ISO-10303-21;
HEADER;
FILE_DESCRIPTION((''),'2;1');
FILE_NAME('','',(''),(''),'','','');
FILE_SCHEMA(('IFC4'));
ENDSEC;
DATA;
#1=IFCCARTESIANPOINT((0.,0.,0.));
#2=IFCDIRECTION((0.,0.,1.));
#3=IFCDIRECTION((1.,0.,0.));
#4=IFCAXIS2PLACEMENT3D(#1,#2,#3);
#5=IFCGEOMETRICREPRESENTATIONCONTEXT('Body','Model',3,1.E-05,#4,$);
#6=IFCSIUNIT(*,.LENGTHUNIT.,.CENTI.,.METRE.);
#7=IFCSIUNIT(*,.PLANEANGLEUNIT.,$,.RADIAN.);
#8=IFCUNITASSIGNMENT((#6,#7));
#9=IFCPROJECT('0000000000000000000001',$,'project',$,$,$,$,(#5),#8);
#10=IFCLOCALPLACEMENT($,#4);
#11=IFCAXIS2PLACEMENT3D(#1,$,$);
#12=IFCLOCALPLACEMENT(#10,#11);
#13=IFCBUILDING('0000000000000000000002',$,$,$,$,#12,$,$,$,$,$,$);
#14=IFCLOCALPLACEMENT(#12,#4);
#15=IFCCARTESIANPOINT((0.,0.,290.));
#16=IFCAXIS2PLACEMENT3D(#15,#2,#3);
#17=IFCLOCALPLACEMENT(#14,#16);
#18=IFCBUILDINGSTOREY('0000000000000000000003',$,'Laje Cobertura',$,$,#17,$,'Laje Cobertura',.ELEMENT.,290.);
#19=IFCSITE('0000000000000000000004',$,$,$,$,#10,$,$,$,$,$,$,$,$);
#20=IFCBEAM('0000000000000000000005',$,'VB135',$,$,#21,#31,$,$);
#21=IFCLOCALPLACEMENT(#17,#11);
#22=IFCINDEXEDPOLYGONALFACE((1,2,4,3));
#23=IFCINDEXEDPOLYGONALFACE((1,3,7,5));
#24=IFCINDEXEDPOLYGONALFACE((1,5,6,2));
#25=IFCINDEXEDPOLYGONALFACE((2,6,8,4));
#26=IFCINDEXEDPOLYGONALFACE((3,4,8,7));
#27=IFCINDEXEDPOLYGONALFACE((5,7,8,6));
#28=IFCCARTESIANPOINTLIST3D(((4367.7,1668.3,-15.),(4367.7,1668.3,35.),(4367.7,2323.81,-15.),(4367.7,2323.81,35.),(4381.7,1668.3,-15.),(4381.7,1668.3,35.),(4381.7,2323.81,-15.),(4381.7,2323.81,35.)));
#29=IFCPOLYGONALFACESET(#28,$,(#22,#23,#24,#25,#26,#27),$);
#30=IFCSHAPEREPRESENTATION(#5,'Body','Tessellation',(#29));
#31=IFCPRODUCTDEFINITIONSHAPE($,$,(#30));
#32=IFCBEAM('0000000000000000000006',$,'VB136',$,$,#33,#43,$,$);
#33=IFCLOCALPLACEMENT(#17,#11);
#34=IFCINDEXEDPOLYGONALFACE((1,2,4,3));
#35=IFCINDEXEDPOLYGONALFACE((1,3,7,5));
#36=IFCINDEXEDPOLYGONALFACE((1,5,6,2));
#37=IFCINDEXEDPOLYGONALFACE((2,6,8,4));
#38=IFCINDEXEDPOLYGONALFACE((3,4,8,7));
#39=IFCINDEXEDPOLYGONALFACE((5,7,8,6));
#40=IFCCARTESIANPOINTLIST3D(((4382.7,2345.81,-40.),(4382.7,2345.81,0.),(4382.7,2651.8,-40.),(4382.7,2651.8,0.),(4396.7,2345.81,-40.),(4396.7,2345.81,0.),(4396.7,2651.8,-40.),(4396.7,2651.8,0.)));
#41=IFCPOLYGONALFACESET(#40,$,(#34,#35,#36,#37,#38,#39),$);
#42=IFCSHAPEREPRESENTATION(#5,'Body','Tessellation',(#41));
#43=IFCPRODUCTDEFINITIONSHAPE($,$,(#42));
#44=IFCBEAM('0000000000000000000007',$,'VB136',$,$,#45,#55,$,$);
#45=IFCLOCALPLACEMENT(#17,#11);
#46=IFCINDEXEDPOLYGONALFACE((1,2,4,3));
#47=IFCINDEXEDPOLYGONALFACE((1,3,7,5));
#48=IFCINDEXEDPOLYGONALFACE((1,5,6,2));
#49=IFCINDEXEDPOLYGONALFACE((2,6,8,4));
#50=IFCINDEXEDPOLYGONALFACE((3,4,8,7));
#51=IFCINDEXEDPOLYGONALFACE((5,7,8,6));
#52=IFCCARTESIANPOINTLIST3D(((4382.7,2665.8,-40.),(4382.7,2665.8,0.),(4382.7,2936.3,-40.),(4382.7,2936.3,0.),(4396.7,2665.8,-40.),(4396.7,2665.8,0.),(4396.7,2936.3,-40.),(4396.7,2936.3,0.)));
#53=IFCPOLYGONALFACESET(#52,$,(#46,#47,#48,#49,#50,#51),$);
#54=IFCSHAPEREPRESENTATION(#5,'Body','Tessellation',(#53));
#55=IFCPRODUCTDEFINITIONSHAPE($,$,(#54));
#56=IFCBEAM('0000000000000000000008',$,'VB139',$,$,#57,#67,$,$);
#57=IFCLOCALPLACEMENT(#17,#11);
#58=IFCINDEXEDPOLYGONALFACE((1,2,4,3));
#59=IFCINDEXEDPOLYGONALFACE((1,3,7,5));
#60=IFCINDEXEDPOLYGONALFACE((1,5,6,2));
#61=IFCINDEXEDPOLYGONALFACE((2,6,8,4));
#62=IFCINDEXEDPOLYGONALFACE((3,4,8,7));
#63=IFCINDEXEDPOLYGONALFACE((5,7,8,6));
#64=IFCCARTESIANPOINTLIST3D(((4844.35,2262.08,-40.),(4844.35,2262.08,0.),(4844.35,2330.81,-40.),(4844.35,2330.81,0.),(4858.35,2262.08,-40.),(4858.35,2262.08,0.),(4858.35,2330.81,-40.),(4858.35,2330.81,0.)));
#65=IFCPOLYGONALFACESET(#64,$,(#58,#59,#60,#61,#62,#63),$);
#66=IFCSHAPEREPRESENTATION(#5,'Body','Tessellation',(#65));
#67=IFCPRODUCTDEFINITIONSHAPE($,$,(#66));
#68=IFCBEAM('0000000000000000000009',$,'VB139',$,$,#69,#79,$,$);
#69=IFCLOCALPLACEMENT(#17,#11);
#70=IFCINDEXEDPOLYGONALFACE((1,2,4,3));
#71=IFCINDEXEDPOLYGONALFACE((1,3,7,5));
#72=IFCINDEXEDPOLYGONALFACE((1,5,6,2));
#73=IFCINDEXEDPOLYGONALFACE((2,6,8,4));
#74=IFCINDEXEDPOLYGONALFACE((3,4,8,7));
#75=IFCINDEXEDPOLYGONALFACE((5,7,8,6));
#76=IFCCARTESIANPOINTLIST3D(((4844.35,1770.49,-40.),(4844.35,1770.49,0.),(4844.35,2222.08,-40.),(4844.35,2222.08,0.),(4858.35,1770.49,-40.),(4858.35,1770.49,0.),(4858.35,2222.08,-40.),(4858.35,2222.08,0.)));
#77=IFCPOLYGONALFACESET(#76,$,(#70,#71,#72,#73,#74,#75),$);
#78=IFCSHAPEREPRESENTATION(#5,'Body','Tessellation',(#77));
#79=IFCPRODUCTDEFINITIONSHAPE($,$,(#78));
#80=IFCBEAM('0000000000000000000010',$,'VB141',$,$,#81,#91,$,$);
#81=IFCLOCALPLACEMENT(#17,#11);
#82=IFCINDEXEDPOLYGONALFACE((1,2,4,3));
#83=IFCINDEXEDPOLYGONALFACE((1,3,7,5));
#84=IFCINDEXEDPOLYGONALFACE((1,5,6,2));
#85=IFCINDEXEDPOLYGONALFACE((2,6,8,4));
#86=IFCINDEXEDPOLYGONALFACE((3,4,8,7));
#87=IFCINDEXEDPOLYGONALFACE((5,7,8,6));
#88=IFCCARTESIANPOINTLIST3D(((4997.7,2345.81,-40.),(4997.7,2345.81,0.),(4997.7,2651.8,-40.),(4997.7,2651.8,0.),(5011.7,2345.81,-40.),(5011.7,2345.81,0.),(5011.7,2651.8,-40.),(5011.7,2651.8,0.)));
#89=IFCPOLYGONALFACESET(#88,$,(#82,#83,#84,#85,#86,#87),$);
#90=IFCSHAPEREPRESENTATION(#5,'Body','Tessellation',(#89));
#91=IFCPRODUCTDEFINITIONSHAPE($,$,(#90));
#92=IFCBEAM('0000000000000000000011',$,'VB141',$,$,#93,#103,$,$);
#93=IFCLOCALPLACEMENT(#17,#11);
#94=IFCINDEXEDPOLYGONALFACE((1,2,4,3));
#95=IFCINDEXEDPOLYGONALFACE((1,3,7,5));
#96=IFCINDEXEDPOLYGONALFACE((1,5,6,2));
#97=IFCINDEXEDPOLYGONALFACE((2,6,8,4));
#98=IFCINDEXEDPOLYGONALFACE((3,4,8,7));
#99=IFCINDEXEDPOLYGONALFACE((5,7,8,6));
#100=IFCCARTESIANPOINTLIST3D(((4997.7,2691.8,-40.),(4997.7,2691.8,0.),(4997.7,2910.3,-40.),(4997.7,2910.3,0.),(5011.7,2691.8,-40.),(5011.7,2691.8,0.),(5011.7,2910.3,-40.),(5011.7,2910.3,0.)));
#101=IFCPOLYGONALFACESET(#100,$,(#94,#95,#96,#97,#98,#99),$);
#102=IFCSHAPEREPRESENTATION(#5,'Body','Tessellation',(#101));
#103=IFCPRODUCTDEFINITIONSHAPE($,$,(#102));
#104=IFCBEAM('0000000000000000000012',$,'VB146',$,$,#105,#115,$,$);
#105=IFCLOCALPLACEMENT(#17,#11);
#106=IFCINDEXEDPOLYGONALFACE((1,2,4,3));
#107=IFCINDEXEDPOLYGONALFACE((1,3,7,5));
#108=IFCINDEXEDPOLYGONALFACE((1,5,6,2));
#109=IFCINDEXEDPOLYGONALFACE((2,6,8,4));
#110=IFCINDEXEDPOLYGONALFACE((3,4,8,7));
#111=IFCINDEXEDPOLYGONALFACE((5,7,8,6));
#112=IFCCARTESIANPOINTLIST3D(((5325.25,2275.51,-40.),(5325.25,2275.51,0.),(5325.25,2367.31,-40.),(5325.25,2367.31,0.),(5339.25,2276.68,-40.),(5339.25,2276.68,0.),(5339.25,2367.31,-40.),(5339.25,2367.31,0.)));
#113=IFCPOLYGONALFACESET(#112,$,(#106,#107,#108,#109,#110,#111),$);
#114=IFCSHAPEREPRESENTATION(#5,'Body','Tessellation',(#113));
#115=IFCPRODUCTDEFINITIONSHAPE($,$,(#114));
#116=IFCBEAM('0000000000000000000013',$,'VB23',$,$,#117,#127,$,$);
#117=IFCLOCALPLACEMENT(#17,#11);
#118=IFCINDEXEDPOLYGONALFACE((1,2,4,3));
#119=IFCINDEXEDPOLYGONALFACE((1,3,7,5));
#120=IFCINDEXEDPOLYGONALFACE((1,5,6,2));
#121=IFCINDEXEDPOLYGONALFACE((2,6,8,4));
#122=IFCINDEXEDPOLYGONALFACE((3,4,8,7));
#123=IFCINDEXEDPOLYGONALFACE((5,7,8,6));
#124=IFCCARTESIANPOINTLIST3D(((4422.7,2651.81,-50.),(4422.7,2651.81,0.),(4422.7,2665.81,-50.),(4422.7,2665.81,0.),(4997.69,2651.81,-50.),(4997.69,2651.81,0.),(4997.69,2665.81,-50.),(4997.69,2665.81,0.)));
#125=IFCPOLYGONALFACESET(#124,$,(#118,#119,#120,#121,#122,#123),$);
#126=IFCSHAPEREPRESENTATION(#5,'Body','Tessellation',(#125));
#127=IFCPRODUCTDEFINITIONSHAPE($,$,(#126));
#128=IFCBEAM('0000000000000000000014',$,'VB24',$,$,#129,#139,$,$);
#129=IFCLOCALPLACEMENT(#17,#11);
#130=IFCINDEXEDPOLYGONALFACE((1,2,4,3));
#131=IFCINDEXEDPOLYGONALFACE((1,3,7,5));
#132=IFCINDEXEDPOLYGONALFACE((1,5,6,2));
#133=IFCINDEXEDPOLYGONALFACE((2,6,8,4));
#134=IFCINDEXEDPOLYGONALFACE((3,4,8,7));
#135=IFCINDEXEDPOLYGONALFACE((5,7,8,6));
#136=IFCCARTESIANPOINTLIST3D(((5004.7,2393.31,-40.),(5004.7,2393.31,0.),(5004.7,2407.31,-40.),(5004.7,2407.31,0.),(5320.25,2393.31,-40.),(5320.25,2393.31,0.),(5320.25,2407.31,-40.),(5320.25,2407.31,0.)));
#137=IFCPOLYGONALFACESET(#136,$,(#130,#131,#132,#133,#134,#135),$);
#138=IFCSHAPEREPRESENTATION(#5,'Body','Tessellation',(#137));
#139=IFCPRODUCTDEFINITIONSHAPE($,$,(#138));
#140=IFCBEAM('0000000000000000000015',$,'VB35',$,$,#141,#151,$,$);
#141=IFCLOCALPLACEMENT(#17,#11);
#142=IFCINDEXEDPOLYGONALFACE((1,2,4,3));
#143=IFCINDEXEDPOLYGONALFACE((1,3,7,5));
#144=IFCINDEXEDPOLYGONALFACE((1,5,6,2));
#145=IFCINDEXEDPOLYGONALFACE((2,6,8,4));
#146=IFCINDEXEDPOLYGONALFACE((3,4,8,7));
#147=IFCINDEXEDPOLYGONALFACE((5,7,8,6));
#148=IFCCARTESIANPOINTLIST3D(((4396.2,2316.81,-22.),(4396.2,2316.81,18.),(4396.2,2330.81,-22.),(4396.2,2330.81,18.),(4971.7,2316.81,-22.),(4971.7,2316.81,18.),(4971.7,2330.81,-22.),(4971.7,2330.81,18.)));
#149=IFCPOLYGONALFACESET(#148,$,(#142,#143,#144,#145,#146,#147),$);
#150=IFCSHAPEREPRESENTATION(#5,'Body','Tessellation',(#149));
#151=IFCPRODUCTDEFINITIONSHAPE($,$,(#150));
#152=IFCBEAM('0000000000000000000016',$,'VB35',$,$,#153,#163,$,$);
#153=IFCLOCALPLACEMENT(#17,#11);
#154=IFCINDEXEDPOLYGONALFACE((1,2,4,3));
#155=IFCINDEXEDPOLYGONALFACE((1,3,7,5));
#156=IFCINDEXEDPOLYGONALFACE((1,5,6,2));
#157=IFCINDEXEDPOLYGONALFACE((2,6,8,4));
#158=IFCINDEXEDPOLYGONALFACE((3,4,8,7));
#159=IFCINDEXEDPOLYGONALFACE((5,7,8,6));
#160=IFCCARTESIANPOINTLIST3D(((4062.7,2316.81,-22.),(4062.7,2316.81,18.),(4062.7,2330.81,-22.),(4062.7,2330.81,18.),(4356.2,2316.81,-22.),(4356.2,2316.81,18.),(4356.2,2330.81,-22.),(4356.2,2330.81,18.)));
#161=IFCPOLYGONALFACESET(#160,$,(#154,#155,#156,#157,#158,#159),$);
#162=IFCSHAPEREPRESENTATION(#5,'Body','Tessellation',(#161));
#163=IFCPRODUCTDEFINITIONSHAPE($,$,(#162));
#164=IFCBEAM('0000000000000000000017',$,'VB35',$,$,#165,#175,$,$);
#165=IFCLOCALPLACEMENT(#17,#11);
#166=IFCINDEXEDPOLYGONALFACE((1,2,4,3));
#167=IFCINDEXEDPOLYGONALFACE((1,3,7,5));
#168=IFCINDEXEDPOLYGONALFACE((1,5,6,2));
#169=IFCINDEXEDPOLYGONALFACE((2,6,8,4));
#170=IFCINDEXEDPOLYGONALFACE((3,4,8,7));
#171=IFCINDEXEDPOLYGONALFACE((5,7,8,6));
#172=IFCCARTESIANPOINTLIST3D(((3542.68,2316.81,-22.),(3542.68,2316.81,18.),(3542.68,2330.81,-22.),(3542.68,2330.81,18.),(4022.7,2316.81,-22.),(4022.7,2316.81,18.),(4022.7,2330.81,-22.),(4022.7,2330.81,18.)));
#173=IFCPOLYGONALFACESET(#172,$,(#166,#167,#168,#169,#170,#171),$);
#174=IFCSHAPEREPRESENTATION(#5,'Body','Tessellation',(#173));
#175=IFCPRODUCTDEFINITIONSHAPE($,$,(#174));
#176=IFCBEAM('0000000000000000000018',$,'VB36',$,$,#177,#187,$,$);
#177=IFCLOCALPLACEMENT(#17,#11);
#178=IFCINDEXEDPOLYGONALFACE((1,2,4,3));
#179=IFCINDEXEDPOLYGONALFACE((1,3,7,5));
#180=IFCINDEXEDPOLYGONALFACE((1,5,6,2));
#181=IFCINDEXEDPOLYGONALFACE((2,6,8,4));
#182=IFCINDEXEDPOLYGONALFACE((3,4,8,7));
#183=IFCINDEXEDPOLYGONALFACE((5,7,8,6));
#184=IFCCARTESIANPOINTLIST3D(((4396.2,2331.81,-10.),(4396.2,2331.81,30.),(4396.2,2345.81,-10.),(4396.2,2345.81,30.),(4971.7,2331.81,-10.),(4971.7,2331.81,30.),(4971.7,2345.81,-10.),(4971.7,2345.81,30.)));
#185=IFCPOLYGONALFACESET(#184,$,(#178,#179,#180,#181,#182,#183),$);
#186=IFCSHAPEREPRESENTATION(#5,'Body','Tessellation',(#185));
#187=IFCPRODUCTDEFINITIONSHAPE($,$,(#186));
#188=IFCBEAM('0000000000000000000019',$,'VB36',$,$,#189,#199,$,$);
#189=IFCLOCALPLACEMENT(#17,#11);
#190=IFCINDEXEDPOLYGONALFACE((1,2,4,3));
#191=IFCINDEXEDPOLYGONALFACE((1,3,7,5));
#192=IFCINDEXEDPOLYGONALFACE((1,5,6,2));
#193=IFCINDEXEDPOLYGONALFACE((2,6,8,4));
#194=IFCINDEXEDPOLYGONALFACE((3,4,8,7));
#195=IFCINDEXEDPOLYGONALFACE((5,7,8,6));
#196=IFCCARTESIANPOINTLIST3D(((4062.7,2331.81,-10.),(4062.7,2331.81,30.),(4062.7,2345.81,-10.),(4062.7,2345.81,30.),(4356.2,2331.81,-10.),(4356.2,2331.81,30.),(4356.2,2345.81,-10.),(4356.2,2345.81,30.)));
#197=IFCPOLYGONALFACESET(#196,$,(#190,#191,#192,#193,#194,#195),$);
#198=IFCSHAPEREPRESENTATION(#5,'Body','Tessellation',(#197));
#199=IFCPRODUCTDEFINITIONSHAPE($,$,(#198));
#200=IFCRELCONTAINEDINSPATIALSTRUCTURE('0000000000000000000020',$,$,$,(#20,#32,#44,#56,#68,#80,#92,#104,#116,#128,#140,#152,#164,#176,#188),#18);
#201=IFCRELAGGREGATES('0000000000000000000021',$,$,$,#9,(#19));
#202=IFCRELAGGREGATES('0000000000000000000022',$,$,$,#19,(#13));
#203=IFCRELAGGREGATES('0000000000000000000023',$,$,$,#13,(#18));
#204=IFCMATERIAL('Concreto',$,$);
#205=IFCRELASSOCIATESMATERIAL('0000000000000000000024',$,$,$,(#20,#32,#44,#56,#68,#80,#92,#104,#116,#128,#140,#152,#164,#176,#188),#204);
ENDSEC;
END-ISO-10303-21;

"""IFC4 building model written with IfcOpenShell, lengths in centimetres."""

from ifc_helpers import new_model, si_unit, frame, origin, origin_with_axes, origin_2d_with_axis, place, context, project, spatial, rectangle, extrude, clip, halfspace, material, element, save


model = new_model("IFC4")

# Units and contexts
model_context = context("Model", 3, precision=1e-05, world=origin_with_axes(), identifier="Body")
ifc_project = project(units=[si_unit("LENGTHUNIT", "METRE", prefix="CENTI"), si_unit("PLANEANGLEUNIT", "RADIAN")], contexts=[model_context])

# Site, building, storey
site_placement = place(None, origin_with_axes())
site = spatial("IfcSite", under=ifc_project, at=site_placement)
building_placement = place(site_placement, origin())
building = spatial("IfcBuilding", under=site, at=building_placement)
placement = place(building_placement, origin_with_axes())
storey_placement = place(placement, frame((0.0, 0.0, 290.0), z_axis=(0.0, 0.0, 1.0), x_axis=(1.0, 0.0, 0.0)))
storey = spatial("IfcBuildingStorey", under=building, at=storey_placement, Name="Laje Cobertura", LongName="Laje Cobertura", CompositionType="ELEMENT", Elevation=290.0)

# Shared definitions
ifc_material = material(Name="Concreto")

# Beams
for number, where, z_axis, x_axis, name in (
    (1, (4374.7, 1996.06, 35.0), (0.0, 0.0, 1.0), (1.0, 0.0, 0.0), "VB135"),
):
    element("IfcBeam", number, at=place(storey_placement, frame(where, z_axis=z_axis, x_axis=x_axis)), inside=storey, material=ifc_material, Name=name, context=model_context, shape_type="SolidModel", body=[
        extrude(rectangle(XDim=14.0, YDim=50.0, at=origin_2d_with_axis()), frame((0.0, -327.75, -25.0), z_axis=(0.0, 1.0, 0.0), x_axis=(1.0, 0.0, 0.0)), (0.0, 0.0, 1.0), 655.51),
    ])
beam_1_placement = place(storey_placement, frame((4389.7, 2498.8, 0.0), z_axis=(0.0, 0.0, 1.0), x_axis=(1.0, 0.0, 0.0)))
element("IfcBeam", 2, at=beam_1_placement, inside=storey, material=ifc_material, Name="VB136", context=model_context, shape_type="SolidModel", body=[
    extrude(rectangle(XDim=14.0, YDim=40.0, at=origin_2d_with_axis()), frame((0.0, -153.0, -20.0), z_axis=(0.0, 1.0, 0.0), x_axis=(1.0, 0.0, 0.0)), (0.0, 0.0, 1.0), 305.99),
])
beam_2_placement = place(storey_placement, frame((4389.7, 2801.05, 0.0), z_axis=(0.0, 0.0, 1.0), x_axis=(1.0, 0.0, 0.0)))
element("IfcBeam", 3, at=beam_2_placement, inside=storey, material=ifc_material, Name="VB136", context=model_context, shape_type="SolidModel", body=[
    extrude(rectangle(XDim=14.0, YDim=40.0, at=origin_2d_with_axis()), frame((0.0, -135.25, -20.0), z_axis=(0.0, 1.0, 0.0), x_axis=(1.0, 0.0, 0.0)), (0.0, 0.0, 1.0), 270.5),
])
beam_3_placement = place(storey_placement, frame((4851.35, 2296.45, 0.0), z_axis=(0.0, 0.0, 1.0), x_axis=(1.0, 0.0, 0.0)))
element("IfcBeam", 4, at=beam_3_placement, inside=storey, material=ifc_material, Name="VB139", context=model_context, shape_type="SolidModel", body=[
    extrude(rectangle(XDim=14.0, YDim=40.0, at=origin_2d_with_axis()), frame((0.0, -34.37, -20.0), z_axis=(0.0, 1.0, 0.0), x_axis=(1.0, 0.0, 0.0)), (0.0, 0.0, 1.0), 68.73),
])
beam_4_placement = place(storey_placement, frame((4851.35, 1996.29, 0.0), z_axis=(0.0, 0.0, 1.0), x_axis=(1.0, 0.0, 0.0)))
element("IfcBeam", 5, at=beam_4_placement, inside=storey, material=ifc_material, Name="VB139", context=model_context, shape_type="SolidModel", body=[
    extrude(rectangle(XDim=14.0, YDim=40.0, at=origin_2d_with_axis()), frame((0.0, -225.79, -20.0), z_axis=(0.0, 1.0, 0.0), x_axis=(1.0, 0.0, 0.0)), (0.0, 0.0, 1.0), 451.59),
])
beam_5_placement = place(storey_placement, frame((5004.7, 2498.8, 0.0), z_axis=(0.0, 0.0, 1.0), x_axis=(1.0, 0.0, 0.0)))
element("IfcBeam", 6, at=beam_5_placement, inside=storey, material=ifc_material, Name="VB141", context=model_context, shape_type="SolidModel", body=[
    extrude(rectangle(XDim=14.0, YDim=40.0, at=origin_2d_with_axis()), frame((0.0, -153.0, -20.0), z_axis=(0.0, 1.0, 0.0), x_axis=(1.0, 0.0, 0.0)), (0.0, 0.0, 1.0), 305.99),
])
beam_6_placement = place(storey_placement, frame((5004.7, 2801.05, 0.0), z_axis=(0.0, 0.0, 1.0), x_axis=(1.0, 0.0, 0.0)))
element("IfcBeam", 7, at=beam_6_placement, inside=storey, material=ifc_material, Name="VB141", context=model_context, shape_type="SolidModel", body=[
    extrude(rectangle(XDim=14.0, YDim=40.0, at=origin_2d_with_axis()), frame((0.0, -109.25, -20.0), z_axis=(0.0, 1.0, 0.0), x_axis=(1.0, 0.0, 0.0)), (0.0, 0.0, 1.0), 218.5),
])
beam_7_placement = place(storey_placement, frame((5332.25, 2321.41, 0.0), z_axis=(0.0, 0.0, 1.0), x_axis=(1.0, 0.0, 0.0)))
element("IfcBeam", 8, at=beam_7_placement, inside=storey, material=ifc_material, Name="VB146", context=model_context, shape_type="Clipping", body=[
    clip(extrude(rectangle(XDim=14.0, YDim=40.0, at=origin_2d_with_axis()), frame((0.0, -45.9, -20.0), z_axis=(0.0, 1.0, 0.0), x_axis=(1.0, 0.0, 0.0)), (0.0, 0.0, 1.0), 91.8), halfspace(frame((-7.0, -45.9, 0.0), z_axis=(-0.083638, 0.996496, 0.0), x_axis=(0.0, 0.0, -0.083638)), True)),
])
beam_8_placement = place(storey_placement, frame((4710.19, 2658.81, 0.0), z_axis=(0.0, 0.0, 1.0), x_axis=(1.0, 0.0, 0.0)))
element("IfcBeam", 9, at=beam_8_placement, inside=storey, material=ifc_material, Name="VB23", context=model_context, shape_type="SolidModel", body=[
    extrude(rectangle(XDim=14.0, YDim=50.0, at=origin_2d_with_axis()), frame((-287.5, 0.0, -25.0), z_axis=(1.0, 0.0, 0.0), x_axis=(0.0, 1.0, 0.0)), (0.0, 0.0, 1.0), 574.99),
])
beam_9_placement = place(storey_placement, frame((5162.48, 2400.31, 0.0), z_axis=(0.0, 0.0, 1.0), x_axis=(1.0, 0.0, 0.0)))
element("IfcBeam", 10, at=beam_9_placement, inside=storey, material=ifc_material, Name="VB24", context=model_context, shape_type="SolidModel", body=[
    extrude(rectangle(XDim=14.0, YDim=40.0, at=origin_2d_with_axis()), frame((-157.78, 0.0, -20.0), z_axis=(1.0, 0.0, 0.0), x_axis=(0.0, 1.0, 0.0)), (0.0, 0.0, 1.0), 315.55),
])
beam_10_placement = place(storey_placement, frame((4683.95, 2323.81, 18.0), z_axis=(0.0, 0.0, 1.0), x_axis=(1.0, 0.0, 0.0)))
element("IfcBeam", 11, at=beam_10_placement, inside=storey, material=ifc_material, Name="VB35", context=model_context, shape_type="SolidModel", body=[
    extrude(rectangle(XDim=14.0, YDim=40.0, at=origin_2d_with_axis()), frame((-287.75, 0.0, -20.0), z_axis=(1.0, 0.0, 0.0), x_axis=(0.0, 1.0, 0.0)), (0.0, 0.0, 1.0), 575.5),
])
beam_11_placement = place(storey_placement, frame((4209.45, 2323.81, 18.0), z_axis=(0.0, 0.0, 1.0), x_axis=(1.0, 0.0, 0.0)))
element("IfcBeam", 12, at=beam_11_placement, inside=storey, material=ifc_material, Name="VB35", context=model_context, shape_type="SolidModel", body=[
    extrude(rectangle(XDim=14.0, YDim=40.0, at=origin_2d_with_axis()), frame((-146.75, 0.0, -20.0), z_axis=(1.0, 0.0, 0.0), x_axis=(0.0, 1.0, 0.0)), (0.0, 0.0, 1.0), 293.5),
])
beam_12_placement = place(storey_placement, frame((3782.69, 2323.81, 18.0), z_axis=(0.0, 0.0, 1.0), x_axis=(1.0, 0.0, 0.0)))
element("IfcBeam", 13, at=beam_12_placement, inside=storey, material=ifc_material, Name="VB35", context=model_context, shape_type="SolidModel", body=[
    extrude(rectangle(XDim=14.0, YDim=40.0, at=origin_2d_with_axis()), frame((-240.01, 0.0, -20.0), z_axis=(1.0, 0.0, 0.0), x_axis=(0.0, 1.0, 0.0)), (0.0, 0.0, 1.0), 480.02),
])
beam_13_placement = place(storey_placement, frame((4683.95, 2338.81, 30.0), z_axis=(0.0, 0.0, 1.0), x_axis=(1.0, 0.0, 0.0)))
element("IfcBeam", 14, at=beam_13_placement, inside=storey, material=ifc_material, Name="VB36", context=model_context, shape_type="SolidModel", body=[
    extrude(rectangle(XDim=14.0, YDim=40.0, at=origin_2d_with_axis()), frame((-287.75, 0.0, -20.0), z_axis=(1.0, 0.0, 0.0), x_axis=(0.0, 1.0, 0.0)), (0.0, 0.0, 1.0), 575.5),
])
beam_14_placement = place(storey_placement, frame((4209.45, 2338.81, 30.0), z_axis=(0.0, 0.0, 1.0), x_axis=(1.0, 0.0, 0.0)))
element("IfcBeam", 15, at=beam_14_placement, inside=storey, material=ifc_material, Name="VB36", context=model_context, shape_type="SolidModel", body=[
    extrude(rectangle(XDim=14.0, YDim=40.0, at=origin_2d_with_axis()), frame((-146.75, 0.0, -20.0), z_axis=(1.0, 0.0, 0.0), x_axis=(0.0, 1.0, 0.0)), (0.0, 0.0, 1.0), 293.5),
])

save(model, "model.ifc")
